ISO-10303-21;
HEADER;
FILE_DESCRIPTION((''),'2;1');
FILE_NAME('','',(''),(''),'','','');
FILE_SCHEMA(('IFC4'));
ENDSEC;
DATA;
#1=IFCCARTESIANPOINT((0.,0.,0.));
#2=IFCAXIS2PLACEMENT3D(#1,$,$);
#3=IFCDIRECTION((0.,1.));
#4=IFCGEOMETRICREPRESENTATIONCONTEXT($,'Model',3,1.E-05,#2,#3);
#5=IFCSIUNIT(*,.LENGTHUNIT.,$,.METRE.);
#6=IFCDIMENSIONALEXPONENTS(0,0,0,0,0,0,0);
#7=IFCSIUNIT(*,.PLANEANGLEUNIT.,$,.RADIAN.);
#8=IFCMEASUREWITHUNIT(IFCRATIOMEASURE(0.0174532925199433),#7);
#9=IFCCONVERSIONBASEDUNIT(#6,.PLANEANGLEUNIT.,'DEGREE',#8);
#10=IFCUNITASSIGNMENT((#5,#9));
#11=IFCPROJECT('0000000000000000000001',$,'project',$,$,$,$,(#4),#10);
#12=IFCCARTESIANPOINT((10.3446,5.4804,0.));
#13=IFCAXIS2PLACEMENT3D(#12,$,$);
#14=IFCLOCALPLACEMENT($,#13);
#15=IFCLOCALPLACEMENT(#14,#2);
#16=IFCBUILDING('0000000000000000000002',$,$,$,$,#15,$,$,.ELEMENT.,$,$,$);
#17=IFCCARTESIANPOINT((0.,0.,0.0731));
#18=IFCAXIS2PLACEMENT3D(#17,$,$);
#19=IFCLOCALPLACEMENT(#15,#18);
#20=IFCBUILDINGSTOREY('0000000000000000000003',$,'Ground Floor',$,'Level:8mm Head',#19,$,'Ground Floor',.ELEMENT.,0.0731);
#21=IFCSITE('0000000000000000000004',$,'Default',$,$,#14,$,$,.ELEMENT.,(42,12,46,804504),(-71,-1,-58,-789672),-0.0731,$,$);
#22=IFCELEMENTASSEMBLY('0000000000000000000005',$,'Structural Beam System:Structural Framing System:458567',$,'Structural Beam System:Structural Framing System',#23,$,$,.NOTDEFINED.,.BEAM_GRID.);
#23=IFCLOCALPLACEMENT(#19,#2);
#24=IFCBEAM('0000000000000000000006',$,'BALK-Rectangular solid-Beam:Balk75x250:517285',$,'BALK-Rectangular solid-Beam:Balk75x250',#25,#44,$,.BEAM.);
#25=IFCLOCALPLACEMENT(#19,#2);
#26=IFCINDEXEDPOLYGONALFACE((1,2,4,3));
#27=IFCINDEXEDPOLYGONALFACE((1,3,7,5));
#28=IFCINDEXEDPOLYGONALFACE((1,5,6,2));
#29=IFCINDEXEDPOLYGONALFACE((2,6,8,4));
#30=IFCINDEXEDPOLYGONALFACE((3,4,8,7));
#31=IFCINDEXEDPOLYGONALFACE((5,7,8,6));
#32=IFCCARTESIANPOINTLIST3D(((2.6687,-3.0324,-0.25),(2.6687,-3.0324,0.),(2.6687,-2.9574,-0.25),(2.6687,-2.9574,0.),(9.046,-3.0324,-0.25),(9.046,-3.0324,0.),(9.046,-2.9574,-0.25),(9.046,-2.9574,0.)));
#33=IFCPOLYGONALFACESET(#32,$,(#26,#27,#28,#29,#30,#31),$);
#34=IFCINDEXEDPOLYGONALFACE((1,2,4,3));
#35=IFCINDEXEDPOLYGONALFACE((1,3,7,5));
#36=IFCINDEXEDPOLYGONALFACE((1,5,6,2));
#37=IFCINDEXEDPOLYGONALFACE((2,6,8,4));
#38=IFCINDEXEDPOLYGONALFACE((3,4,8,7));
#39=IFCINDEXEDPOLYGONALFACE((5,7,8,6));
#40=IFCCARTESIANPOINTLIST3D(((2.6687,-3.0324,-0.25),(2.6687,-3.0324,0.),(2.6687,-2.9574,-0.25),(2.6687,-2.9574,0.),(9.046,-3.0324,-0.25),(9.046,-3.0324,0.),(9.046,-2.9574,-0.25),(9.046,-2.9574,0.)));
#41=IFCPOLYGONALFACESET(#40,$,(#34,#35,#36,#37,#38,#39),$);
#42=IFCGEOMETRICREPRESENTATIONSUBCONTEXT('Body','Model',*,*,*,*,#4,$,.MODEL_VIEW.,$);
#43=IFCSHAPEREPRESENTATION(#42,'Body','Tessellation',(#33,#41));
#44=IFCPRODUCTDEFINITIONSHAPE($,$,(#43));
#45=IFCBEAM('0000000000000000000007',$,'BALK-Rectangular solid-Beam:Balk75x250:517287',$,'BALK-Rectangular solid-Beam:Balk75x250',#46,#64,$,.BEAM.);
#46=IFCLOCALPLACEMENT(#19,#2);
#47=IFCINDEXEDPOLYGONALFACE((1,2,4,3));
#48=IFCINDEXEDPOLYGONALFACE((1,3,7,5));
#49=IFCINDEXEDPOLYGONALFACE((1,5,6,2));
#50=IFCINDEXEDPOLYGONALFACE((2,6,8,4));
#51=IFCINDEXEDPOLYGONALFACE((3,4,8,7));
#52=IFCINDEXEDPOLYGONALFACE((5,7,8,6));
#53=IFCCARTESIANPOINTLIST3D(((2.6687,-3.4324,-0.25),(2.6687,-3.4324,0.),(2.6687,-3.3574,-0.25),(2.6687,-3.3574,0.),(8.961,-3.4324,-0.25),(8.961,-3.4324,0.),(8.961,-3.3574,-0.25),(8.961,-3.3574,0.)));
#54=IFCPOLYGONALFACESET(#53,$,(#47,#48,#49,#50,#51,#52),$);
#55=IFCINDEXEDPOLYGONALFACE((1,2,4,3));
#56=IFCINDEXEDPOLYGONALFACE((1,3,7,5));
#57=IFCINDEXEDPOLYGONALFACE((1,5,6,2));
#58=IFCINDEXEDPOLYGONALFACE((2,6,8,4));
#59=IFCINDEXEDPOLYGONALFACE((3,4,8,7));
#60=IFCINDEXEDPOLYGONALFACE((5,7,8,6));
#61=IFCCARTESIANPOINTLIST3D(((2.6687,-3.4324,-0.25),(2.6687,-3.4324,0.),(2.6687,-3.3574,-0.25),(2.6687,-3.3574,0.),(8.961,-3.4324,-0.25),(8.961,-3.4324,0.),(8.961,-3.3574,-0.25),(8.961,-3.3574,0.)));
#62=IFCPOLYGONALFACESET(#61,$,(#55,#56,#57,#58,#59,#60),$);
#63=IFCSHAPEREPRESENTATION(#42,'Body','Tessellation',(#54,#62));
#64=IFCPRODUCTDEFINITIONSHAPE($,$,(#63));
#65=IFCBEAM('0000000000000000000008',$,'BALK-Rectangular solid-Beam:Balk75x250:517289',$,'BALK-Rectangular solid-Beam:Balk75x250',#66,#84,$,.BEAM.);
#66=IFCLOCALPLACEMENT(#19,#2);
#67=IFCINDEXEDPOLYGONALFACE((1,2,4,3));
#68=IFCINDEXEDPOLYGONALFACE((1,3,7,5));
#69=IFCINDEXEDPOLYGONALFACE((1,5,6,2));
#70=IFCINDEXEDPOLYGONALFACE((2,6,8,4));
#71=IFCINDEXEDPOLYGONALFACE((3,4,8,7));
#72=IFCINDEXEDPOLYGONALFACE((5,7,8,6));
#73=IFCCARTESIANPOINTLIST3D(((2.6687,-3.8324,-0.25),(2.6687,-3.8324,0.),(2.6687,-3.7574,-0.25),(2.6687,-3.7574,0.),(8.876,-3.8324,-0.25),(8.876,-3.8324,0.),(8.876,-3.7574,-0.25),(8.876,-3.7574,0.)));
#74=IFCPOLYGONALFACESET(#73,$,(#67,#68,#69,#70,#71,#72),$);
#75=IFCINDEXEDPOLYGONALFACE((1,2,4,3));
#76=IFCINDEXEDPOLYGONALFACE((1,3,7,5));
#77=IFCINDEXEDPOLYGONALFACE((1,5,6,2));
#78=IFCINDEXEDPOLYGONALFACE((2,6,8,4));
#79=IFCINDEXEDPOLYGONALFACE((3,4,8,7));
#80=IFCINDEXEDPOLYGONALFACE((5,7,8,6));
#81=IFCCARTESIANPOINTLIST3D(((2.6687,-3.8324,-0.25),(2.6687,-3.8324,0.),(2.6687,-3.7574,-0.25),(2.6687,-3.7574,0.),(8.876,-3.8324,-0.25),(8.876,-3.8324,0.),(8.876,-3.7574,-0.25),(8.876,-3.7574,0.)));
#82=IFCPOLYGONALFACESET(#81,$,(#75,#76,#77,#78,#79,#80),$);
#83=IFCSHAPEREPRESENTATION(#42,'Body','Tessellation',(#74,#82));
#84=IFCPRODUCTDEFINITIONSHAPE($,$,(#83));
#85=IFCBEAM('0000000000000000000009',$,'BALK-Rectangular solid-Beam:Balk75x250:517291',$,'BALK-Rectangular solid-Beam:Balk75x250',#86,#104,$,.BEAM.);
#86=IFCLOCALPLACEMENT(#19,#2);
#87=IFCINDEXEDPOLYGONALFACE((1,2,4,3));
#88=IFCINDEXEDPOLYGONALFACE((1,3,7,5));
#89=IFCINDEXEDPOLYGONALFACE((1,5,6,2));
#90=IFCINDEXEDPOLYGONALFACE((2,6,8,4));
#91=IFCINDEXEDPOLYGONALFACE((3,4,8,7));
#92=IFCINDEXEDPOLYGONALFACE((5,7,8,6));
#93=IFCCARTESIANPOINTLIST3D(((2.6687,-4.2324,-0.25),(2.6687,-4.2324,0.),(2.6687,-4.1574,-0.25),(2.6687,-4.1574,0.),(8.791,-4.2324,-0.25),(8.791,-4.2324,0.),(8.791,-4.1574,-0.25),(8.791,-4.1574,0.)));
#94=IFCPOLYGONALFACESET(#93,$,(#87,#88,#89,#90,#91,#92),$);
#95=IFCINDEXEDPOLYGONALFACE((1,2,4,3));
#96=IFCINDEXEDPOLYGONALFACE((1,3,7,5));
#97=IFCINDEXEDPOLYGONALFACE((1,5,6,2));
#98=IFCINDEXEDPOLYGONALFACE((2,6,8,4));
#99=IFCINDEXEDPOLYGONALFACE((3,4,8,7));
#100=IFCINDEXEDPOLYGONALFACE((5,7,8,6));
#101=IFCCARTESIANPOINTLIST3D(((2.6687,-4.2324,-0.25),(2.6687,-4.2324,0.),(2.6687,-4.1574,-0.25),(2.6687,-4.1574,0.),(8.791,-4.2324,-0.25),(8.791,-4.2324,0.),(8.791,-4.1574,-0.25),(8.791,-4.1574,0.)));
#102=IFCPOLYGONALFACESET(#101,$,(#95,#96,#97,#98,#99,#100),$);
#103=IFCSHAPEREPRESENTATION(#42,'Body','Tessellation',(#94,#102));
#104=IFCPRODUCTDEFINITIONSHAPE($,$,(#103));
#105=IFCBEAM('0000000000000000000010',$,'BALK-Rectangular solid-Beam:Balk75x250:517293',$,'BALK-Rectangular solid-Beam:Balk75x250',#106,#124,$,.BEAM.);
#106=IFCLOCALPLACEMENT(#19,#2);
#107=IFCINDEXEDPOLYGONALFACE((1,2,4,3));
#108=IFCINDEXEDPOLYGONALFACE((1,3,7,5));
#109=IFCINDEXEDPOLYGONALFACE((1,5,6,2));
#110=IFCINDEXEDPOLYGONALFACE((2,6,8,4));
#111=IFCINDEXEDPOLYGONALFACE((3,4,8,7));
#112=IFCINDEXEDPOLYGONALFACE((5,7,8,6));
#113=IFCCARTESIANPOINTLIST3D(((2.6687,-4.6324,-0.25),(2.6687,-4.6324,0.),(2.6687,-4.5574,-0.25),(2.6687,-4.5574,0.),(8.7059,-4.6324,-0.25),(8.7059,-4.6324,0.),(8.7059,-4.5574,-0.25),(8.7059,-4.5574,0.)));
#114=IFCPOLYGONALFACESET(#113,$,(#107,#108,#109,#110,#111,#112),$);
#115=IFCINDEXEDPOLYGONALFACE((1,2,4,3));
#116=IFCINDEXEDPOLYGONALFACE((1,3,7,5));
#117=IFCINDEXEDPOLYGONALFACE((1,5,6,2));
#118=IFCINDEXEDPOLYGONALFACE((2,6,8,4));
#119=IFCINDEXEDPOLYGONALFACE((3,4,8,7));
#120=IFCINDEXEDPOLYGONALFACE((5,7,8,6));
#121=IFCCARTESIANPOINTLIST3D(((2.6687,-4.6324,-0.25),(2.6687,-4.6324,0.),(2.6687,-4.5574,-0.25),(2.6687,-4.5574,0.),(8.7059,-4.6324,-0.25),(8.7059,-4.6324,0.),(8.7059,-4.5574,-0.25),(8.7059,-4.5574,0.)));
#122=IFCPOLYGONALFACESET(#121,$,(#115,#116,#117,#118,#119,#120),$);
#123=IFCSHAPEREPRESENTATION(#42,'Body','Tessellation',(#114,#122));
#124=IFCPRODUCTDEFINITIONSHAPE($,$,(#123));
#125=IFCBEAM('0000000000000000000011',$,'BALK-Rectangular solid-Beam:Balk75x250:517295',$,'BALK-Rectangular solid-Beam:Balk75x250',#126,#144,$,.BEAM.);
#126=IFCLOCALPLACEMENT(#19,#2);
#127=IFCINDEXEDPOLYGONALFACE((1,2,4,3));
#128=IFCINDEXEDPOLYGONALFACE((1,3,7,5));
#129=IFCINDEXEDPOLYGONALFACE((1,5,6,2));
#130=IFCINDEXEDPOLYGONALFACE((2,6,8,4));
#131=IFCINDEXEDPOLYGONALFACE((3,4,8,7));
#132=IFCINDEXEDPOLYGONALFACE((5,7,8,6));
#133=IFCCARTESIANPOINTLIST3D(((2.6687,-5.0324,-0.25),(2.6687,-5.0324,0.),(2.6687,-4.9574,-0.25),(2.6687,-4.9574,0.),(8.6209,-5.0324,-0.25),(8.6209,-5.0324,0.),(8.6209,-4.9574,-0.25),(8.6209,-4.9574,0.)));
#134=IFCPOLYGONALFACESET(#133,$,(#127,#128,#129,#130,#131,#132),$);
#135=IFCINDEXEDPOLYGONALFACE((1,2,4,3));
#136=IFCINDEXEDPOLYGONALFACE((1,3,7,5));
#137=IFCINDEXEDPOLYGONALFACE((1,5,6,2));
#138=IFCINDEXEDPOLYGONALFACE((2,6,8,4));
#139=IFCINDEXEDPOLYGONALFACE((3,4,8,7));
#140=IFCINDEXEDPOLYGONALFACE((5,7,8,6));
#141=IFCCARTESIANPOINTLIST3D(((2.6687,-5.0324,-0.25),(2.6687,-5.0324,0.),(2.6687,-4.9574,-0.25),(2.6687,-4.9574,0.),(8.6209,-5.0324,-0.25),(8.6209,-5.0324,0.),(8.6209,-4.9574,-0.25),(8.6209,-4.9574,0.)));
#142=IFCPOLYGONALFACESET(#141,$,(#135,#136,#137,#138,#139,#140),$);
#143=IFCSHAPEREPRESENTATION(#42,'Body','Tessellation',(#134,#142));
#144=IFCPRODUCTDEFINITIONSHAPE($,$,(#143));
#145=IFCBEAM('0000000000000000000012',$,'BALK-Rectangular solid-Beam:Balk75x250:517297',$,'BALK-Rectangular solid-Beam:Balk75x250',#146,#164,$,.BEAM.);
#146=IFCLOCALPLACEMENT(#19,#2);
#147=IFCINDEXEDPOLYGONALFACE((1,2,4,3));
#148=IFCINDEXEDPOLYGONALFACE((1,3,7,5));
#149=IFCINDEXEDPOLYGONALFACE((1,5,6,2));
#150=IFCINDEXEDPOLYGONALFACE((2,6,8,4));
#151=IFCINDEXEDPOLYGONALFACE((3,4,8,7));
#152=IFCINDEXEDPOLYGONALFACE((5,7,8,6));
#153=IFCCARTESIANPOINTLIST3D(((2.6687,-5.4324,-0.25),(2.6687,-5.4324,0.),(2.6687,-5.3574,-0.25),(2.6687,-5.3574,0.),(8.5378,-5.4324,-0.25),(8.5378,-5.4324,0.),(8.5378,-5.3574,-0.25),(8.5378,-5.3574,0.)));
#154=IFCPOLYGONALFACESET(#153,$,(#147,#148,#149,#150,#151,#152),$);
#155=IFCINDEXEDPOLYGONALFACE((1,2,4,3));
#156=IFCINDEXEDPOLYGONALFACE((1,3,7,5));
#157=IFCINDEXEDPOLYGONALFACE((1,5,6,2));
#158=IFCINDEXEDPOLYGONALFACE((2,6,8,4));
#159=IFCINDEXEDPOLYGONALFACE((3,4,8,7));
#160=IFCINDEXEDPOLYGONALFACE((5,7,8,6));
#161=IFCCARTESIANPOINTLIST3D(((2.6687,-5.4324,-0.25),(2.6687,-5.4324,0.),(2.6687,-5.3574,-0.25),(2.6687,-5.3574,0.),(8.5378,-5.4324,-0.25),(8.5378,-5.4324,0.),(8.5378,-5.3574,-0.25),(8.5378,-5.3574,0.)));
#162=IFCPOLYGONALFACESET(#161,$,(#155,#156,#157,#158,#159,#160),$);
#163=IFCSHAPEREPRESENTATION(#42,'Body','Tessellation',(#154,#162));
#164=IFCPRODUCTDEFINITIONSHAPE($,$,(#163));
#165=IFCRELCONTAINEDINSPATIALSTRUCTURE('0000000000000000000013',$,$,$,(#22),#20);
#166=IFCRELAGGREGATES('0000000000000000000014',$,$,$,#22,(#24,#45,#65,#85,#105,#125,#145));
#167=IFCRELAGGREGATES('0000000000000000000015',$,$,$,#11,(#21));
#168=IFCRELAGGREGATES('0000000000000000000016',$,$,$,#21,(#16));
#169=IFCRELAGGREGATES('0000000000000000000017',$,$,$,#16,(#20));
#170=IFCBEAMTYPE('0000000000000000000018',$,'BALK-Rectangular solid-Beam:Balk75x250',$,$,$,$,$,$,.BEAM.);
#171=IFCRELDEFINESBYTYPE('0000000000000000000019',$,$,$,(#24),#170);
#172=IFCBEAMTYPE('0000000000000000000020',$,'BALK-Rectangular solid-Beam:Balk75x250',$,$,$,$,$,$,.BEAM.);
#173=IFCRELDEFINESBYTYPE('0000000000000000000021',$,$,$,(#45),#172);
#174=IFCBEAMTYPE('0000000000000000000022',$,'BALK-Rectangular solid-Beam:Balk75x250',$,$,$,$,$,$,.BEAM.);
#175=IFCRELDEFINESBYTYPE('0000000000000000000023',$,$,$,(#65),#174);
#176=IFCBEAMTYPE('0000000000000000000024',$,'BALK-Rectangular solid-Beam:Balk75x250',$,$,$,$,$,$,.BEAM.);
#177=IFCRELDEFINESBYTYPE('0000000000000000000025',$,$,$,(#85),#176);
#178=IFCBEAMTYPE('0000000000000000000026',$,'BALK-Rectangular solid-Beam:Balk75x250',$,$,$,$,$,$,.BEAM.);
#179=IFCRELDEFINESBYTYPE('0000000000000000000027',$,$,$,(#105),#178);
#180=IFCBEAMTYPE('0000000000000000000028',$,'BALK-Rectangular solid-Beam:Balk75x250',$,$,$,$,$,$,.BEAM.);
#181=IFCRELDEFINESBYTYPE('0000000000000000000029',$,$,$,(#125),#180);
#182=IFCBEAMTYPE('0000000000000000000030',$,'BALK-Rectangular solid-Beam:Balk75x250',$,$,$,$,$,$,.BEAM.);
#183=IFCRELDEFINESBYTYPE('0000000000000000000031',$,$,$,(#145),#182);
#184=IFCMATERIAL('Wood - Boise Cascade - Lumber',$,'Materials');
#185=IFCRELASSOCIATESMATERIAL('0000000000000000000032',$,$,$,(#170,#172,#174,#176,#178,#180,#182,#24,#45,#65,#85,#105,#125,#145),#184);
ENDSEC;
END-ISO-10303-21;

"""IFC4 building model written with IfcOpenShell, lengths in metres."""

from ifc_helpers import new_model, entity, si_unit, converted_unit, direction, frame, frame_2d, origin, origin_2d_with_axis, place, context, subcontext, project, spatial, rectangle, extrude, source, transform, mapped, material, material_profile, profile_set, profile_usage, type_object, type_shapes, element, aggregate, save


model = new_model("IFC4")

# Units and contexts
model_context = context("Model", 3, precision=1e-05, world=origin(), true_north=direction((0.0, 1.0)))
body_context = subcontext(model_context, "Body", "Model", "MODEL_VIEW")
ifc_project = project(units=[si_unit("LENGTHUNIT", "METRE"), converted_unit("PLANEANGLEUNIT", "DEGREE", entity("IfcRatioMeasure", 0.0174532925199433), si_unit("PLANEANGLEUNIT", "RADIAN"), dimensions=[0, 0, 0, 0, 0, 0, 0])], contexts=[model_context])

# Site, building, storey
site_placement = place(None, frame((10.3446, 5.4804, 0.0)))
site = spatial("IfcSite", under=ifc_project, at=site_placement, Name="Default", CompositionType="ELEMENT", RefLatitude=(42, 12, 46, 804504), RefLongitude=(-71, -1, -58, -789672), RefElevation=-0.0731)
building_placement = place(site_placement, origin())
building = spatial("IfcBuilding", under=site, at=building_placement, CompositionType="ELEMENT")
storey_placement = place(building_placement, frame((0.0, 0.0, 0.0731)))
storey = spatial("IfcBuildingStorey", under=building, at=storey_placement, Name="Ground Floor", ObjectType="Level:8mm Head", LongName="Ground Floor", CompositionType="ELEMENT", Elevation=0.0731)

# Element assembly, beams
assembly_1_placement = place(storey_placement, origin())
assembly_1 = element("IfcElementAssembly", 1, at=assembly_1_placement, inside=storey, Name="Structural Beam System:Structural Framing System:458567", ObjectType="Structural Beam System:Structural Framing System", AssemblyPlace="NOTDEFINED", PredefinedType="BEAM_GRID")
ifc_material_1 = material(Name="Wood - Boise Cascade - Lumber", Category="Materials")
ifc_material_profile = material_profile(ifc_material_1, rectangle(XDim=0.25, YDim=0.075, at=frame_2d((0.0, 0.0), x_axis=(1.0, 0.0))), Name="Balk75x250")
ifc_profile_set = profile_set([ifc_material_profile], Name="Balk75x250")
ifc_profile_usage_1 = profile_usage(ifc_profile_set, cardinal=8)
beam_type_1 = type_object("IfcBeamType", Name="BALK-Rectangular solid-Beam:Balk75x250", PredefinedType="BEAM", material=ifc_profile_set)
shared_shape_1 = source(origin(), body_context, "Body", "SweptSolid", [
    extrude(rectangle(XDim=0.25, YDim=0.075, at=origin_2d_with_axis()), frame((-3.1457, 0.0, 0.0), z_axis=(1.0, 0.0, 0.0), x_axis=(0.0, 0.0, -1.0)), (0.0, 0.0, 1.0), 6.3774),
    extrude(rectangle(XDim=0.25, YDim=0.075, at=origin_2d_with_axis()), frame((-3.1457, 0.0, 0.0), z_axis=(1.0, 0.0, 0.0), x_axis=(0.0, 0.0, -1.0)), (0.0, 0.0, 1.0), 6.3774),
])
type_shapes(beam_type_1, [shared_shape_1])
beam_1_placement = place(assembly_1_placement, frame((5.8144, -2.9949, -0.125)))
beam_1 = element("IfcBeam", 2, at=beam_1_placement, type_object=beam_type_1, material=ifc_profile_usage_1, Name="BALK-Rectangular solid-Beam:Balk75x250:517285", ObjectType="BALK-Rectangular solid-Beam:Balk75x250", PredefinedType="BEAM", context=body_context, shape_type="MappedRepresentation", body=[
    mapped(shared_shape_1, transform((0.0, 0.0, 0.0), scale=1.0)),
])
ifc_profile_usage_2 = profile_usage(ifc_profile_set, cardinal=8)
beam_type_2 = type_object("IfcBeamType", Name="BALK-Rectangular solid-Beam:Balk75x250", PredefinedType="BEAM", material=ifc_profile_set)
shared_shape_2 = source(origin(), body_context, "Body", "SweptSolid", [
    extrude(rectangle(XDim=0.25, YDim=0.075, at=origin_2d_with_axis()), frame((-3.1032, 0.0, 0.0), z_axis=(1.0, 0.0, 0.0), x_axis=(0.0, 0.0, -1.0)), (0.0, 0.0, 1.0), 6.2924),
    extrude(rectangle(XDim=0.25, YDim=0.075, at=origin_2d_with_axis()), frame((-3.1032, 0.0, 0.0), z_axis=(1.0, 0.0, 0.0), x_axis=(0.0, 0.0, -1.0)), (0.0, 0.0, 1.0), 6.2924),
])
type_shapes(beam_type_2, [shared_shape_2])
beam_2_placement = place(assembly_1_placement, frame((5.7719, -3.3949, -0.125)))
beam_2 = element("IfcBeam", 3, at=beam_2_placement, type_object=beam_type_2, material=ifc_profile_usage_2, Name="BALK-Rectangular solid-Beam:Balk75x250:517287", ObjectType="BALK-Rectangular solid-Beam:Balk75x250", PredefinedType="BEAM", context=body_context, shape_type="MappedRepresentation", body=[
    mapped(shared_shape_2, transform((0.0, 0.0, 0.0), scale=1.0)),
])
ifc_profile_usage_3 = profile_usage(ifc_profile_set, cardinal=8)
beam_type_3 = type_object("IfcBeamType", Name="BALK-Rectangular solid-Beam:Balk75x250", PredefinedType="BEAM", material=ifc_profile_set)
shared_shape_3 = source(origin(), body_context, "Body", "SweptSolid", [
    extrude(rectangle(XDim=0.25, YDim=0.075, at=origin_2d_with_axis()), frame((-3.0607, 0.0, 0.0), z_axis=(1.0, 0.0, 0.0), x_axis=(0.0, 0.0, -1.0)), (0.0, 0.0, 1.0), 6.2073),
    extrude(rectangle(XDim=0.25, YDim=0.075, at=origin_2d_with_axis()), frame((-3.0607, 0.0, 0.0), z_axis=(1.0, 0.0, 0.0), x_axis=(0.0, 0.0, -1.0)), (0.0, 0.0, 1.0), 6.2073),
])
type_shapes(beam_type_3, [shared_shape_3])
beam_3_placement = place(assembly_1_placement, frame((5.7294, -3.7949, -0.125)))
beam_3 = element("IfcBeam", 4, at=beam_3_placement, type_object=beam_type_3, material=ifc_profile_usage_3, Name="BALK-Rectangular solid-Beam:Balk75x250:517289", ObjectType="BALK-Rectangular solid-Beam:Balk75x250", PredefinedType="BEAM", context=body_context, shape_type="MappedRepresentation", body=[
    mapped(shared_shape_3, transform((0.0, 0.0, 0.0), scale=1.0)),
])
ifc_profile_usage_4 = profile_usage(ifc_profile_set, cardinal=8)
beam_type_4 = type_object("IfcBeamType", Name="BALK-Rectangular solid-Beam:Balk75x250", PredefinedType="BEAM", material=ifc_profile_set)
shared_shape_4 = source(origin(), body_context, "Body", "SweptSolid", [
    extrude(rectangle(XDim=0.25, YDim=0.075, at=origin_2d_with_axis()), frame((-3.0182, 0.0, 0.0), z_axis=(1.0, 0.0, 0.0), x_axis=(0.0, 0.0, -1.0)), (0.0, 0.0, 1.0), 6.1223),
    extrude(rectangle(XDim=0.25, YDim=0.075, at=origin_2d_with_axis()), frame((-3.0182, 0.0, 0.0), z_axis=(1.0, 0.0, 0.0), x_axis=(0.0, 0.0, -1.0)), (0.0, 0.0, 1.0), 6.1223),
])
type_shapes(beam_type_4, [shared_shape_4])
beam_4_placement = place(assembly_1_placement, frame((5.6869, -4.1949, -0.125)))
beam_4 = element("IfcBeam", 5, at=beam_4_placement, type_object=beam_type_4, material=ifc_profile_usage_4, Name="BALK-Rectangular solid-Beam:Balk75x250:517291", ObjectType="BALK-Rectangular solid-Beam:Balk75x250", PredefinedType="BEAM", context=body_context, shape_type="MappedRepresentation", body=[
    mapped(shared_shape_4, transform((0.0, 0.0, 0.0), scale=1.0)),
])
ifc_profile_usage_5 = profile_usage(ifc_profile_set, cardinal=8)
beam_type_5 = type_object("IfcBeamType", Name="BALK-Rectangular solid-Beam:Balk75x250", PredefinedType="BEAM", material=ifc_profile_set)
shared_shape_5 = source(origin(), body_context, "Body", "SweptSolid", [
    extrude(rectangle(XDim=0.25, YDim=0.075, at=origin_2d_with_axis()), frame((-2.9757, 0.0, 0.0), z_axis=(1.0, 0.0, 0.0), x_axis=(0.0, 0.0, -1.0)), (0.0, 0.0, 1.0), 6.0373),
    extrude(rectangle(XDim=0.25, YDim=0.075, at=origin_2d_with_axis()), frame((-2.9757, 0.0, 0.0), z_axis=(1.0, 0.0, 0.0), x_axis=(0.0, 0.0, -1.0)), (0.0, 0.0, 1.0), 6.0373),
])
type_shapes(beam_type_5, [shared_shape_5])
beam_5_placement = place(assembly_1_placement, frame((5.6444, -4.5949, -0.125)))
beam_5 = element("IfcBeam", 6, at=beam_5_placement, type_object=beam_type_5, material=ifc_profile_usage_5, Name="BALK-Rectangular solid-Beam:Balk75x250:517293", ObjectType="BALK-Rectangular solid-Beam:Balk75x250", PredefinedType="BEAM", context=body_context, shape_type="MappedRepresentation", body=[
    mapped(shared_shape_5, transform((0.0, 0.0, 0.0), scale=1.0)),
])
ifc_profile_usage_6 = profile_usage(ifc_profile_set, cardinal=8)
beam_type_6 = type_object("IfcBeamType", Name="BALK-Rectangular solid-Beam:Balk75x250", PredefinedType="BEAM", material=ifc_profile_set)
shared_shape_6 = source(origin(), body_context, "Body", "SweptSolid", [
    extrude(rectangle(XDim=0.25, YDim=0.075, at=origin_2d_with_axis()), frame((-2.9332, 0.0, 0.0), z_axis=(1.0, 0.0, 0.0), x_axis=(0.0, 0.0, -1.0)), (0.0, 0.0, 1.0), 5.9523),
    extrude(rectangle(XDim=0.25, YDim=0.075, at=origin_2d_with_axis()), frame((-2.9332, 0.0, 0.0), z_axis=(1.0, 0.0, 0.0), x_axis=(0.0, 0.0, -1.0)), (0.0, 0.0, 1.0), 5.9523),
])
type_shapes(beam_type_6, [shared_shape_6])
beam_6_placement = place(assembly_1_placement, frame((5.6018, -4.9949, -0.125)))
beam_6 = element("IfcBeam", 7, at=beam_6_placement, type_object=beam_type_6, material=ifc_profile_usage_6, Name="BALK-Rectangular solid-Beam:Balk75x250:517295", ObjectType="BALK-Rectangular solid-Beam:Balk75x250", PredefinedType="BEAM", context=body_context, shape_type="MappedRepresentation", body=[
    mapped(shared_shape_6, transform((0.0, 0.0, 0.0), scale=1.0)),
])
ifc_profile_usage_7 = profile_usage(ifc_profile_set, cardinal=8)
beam_type_7 = type_object("IfcBeamType", Name="BALK-Rectangular solid-Beam:Balk75x250", PredefinedType="BEAM", material=ifc_profile_set)
shared_shape_7 = source(origin(), body_context, "Body", "SweptSolid", [
    extrude(rectangle(XDim=0.25, YDim=0.075, at=origin_2d_with_axis()), frame((-2.8907, 0.0, 0.0), z_axis=(1.0, 0.0, 0.0), x_axis=(0.0, 0.0, -1.0)), (0.0, 0.0, 1.0), 5.8692),
    extrude(rectangle(XDim=0.25, YDim=0.075, at=origin_2d_with_axis()), frame((-2.8907, 0.0, 0.0), z_axis=(1.0, 0.0, 0.0), x_axis=(0.0, 0.0, -1.0)), (0.0, 0.0, 1.0), 5.8692),
])
type_shapes(beam_type_7, [shared_shape_7])
beam_7_placement = place(assembly_1_placement, frame((5.5593, -5.3949, -0.125)))
beam_7 = element("IfcBeam", 8, at=beam_7_placement, type_object=beam_type_7, material=ifc_profile_usage_7, Name="BALK-Rectangular solid-Beam:Balk75x250:517297", ObjectType="BALK-Rectangular solid-Beam:Balk75x250", PredefinedType="BEAM", context=body_context, shape_type="MappedRepresentation", body=[
    mapped(shared_shape_7, transform((0.0, 0.0, 0.0), scale=1.0)),
])
aggregate(assembly_1, [beam_1, beam_2, beam_3, beam_4, beam_5, beam_6, beam_7])

save(model, "model.ifc")
